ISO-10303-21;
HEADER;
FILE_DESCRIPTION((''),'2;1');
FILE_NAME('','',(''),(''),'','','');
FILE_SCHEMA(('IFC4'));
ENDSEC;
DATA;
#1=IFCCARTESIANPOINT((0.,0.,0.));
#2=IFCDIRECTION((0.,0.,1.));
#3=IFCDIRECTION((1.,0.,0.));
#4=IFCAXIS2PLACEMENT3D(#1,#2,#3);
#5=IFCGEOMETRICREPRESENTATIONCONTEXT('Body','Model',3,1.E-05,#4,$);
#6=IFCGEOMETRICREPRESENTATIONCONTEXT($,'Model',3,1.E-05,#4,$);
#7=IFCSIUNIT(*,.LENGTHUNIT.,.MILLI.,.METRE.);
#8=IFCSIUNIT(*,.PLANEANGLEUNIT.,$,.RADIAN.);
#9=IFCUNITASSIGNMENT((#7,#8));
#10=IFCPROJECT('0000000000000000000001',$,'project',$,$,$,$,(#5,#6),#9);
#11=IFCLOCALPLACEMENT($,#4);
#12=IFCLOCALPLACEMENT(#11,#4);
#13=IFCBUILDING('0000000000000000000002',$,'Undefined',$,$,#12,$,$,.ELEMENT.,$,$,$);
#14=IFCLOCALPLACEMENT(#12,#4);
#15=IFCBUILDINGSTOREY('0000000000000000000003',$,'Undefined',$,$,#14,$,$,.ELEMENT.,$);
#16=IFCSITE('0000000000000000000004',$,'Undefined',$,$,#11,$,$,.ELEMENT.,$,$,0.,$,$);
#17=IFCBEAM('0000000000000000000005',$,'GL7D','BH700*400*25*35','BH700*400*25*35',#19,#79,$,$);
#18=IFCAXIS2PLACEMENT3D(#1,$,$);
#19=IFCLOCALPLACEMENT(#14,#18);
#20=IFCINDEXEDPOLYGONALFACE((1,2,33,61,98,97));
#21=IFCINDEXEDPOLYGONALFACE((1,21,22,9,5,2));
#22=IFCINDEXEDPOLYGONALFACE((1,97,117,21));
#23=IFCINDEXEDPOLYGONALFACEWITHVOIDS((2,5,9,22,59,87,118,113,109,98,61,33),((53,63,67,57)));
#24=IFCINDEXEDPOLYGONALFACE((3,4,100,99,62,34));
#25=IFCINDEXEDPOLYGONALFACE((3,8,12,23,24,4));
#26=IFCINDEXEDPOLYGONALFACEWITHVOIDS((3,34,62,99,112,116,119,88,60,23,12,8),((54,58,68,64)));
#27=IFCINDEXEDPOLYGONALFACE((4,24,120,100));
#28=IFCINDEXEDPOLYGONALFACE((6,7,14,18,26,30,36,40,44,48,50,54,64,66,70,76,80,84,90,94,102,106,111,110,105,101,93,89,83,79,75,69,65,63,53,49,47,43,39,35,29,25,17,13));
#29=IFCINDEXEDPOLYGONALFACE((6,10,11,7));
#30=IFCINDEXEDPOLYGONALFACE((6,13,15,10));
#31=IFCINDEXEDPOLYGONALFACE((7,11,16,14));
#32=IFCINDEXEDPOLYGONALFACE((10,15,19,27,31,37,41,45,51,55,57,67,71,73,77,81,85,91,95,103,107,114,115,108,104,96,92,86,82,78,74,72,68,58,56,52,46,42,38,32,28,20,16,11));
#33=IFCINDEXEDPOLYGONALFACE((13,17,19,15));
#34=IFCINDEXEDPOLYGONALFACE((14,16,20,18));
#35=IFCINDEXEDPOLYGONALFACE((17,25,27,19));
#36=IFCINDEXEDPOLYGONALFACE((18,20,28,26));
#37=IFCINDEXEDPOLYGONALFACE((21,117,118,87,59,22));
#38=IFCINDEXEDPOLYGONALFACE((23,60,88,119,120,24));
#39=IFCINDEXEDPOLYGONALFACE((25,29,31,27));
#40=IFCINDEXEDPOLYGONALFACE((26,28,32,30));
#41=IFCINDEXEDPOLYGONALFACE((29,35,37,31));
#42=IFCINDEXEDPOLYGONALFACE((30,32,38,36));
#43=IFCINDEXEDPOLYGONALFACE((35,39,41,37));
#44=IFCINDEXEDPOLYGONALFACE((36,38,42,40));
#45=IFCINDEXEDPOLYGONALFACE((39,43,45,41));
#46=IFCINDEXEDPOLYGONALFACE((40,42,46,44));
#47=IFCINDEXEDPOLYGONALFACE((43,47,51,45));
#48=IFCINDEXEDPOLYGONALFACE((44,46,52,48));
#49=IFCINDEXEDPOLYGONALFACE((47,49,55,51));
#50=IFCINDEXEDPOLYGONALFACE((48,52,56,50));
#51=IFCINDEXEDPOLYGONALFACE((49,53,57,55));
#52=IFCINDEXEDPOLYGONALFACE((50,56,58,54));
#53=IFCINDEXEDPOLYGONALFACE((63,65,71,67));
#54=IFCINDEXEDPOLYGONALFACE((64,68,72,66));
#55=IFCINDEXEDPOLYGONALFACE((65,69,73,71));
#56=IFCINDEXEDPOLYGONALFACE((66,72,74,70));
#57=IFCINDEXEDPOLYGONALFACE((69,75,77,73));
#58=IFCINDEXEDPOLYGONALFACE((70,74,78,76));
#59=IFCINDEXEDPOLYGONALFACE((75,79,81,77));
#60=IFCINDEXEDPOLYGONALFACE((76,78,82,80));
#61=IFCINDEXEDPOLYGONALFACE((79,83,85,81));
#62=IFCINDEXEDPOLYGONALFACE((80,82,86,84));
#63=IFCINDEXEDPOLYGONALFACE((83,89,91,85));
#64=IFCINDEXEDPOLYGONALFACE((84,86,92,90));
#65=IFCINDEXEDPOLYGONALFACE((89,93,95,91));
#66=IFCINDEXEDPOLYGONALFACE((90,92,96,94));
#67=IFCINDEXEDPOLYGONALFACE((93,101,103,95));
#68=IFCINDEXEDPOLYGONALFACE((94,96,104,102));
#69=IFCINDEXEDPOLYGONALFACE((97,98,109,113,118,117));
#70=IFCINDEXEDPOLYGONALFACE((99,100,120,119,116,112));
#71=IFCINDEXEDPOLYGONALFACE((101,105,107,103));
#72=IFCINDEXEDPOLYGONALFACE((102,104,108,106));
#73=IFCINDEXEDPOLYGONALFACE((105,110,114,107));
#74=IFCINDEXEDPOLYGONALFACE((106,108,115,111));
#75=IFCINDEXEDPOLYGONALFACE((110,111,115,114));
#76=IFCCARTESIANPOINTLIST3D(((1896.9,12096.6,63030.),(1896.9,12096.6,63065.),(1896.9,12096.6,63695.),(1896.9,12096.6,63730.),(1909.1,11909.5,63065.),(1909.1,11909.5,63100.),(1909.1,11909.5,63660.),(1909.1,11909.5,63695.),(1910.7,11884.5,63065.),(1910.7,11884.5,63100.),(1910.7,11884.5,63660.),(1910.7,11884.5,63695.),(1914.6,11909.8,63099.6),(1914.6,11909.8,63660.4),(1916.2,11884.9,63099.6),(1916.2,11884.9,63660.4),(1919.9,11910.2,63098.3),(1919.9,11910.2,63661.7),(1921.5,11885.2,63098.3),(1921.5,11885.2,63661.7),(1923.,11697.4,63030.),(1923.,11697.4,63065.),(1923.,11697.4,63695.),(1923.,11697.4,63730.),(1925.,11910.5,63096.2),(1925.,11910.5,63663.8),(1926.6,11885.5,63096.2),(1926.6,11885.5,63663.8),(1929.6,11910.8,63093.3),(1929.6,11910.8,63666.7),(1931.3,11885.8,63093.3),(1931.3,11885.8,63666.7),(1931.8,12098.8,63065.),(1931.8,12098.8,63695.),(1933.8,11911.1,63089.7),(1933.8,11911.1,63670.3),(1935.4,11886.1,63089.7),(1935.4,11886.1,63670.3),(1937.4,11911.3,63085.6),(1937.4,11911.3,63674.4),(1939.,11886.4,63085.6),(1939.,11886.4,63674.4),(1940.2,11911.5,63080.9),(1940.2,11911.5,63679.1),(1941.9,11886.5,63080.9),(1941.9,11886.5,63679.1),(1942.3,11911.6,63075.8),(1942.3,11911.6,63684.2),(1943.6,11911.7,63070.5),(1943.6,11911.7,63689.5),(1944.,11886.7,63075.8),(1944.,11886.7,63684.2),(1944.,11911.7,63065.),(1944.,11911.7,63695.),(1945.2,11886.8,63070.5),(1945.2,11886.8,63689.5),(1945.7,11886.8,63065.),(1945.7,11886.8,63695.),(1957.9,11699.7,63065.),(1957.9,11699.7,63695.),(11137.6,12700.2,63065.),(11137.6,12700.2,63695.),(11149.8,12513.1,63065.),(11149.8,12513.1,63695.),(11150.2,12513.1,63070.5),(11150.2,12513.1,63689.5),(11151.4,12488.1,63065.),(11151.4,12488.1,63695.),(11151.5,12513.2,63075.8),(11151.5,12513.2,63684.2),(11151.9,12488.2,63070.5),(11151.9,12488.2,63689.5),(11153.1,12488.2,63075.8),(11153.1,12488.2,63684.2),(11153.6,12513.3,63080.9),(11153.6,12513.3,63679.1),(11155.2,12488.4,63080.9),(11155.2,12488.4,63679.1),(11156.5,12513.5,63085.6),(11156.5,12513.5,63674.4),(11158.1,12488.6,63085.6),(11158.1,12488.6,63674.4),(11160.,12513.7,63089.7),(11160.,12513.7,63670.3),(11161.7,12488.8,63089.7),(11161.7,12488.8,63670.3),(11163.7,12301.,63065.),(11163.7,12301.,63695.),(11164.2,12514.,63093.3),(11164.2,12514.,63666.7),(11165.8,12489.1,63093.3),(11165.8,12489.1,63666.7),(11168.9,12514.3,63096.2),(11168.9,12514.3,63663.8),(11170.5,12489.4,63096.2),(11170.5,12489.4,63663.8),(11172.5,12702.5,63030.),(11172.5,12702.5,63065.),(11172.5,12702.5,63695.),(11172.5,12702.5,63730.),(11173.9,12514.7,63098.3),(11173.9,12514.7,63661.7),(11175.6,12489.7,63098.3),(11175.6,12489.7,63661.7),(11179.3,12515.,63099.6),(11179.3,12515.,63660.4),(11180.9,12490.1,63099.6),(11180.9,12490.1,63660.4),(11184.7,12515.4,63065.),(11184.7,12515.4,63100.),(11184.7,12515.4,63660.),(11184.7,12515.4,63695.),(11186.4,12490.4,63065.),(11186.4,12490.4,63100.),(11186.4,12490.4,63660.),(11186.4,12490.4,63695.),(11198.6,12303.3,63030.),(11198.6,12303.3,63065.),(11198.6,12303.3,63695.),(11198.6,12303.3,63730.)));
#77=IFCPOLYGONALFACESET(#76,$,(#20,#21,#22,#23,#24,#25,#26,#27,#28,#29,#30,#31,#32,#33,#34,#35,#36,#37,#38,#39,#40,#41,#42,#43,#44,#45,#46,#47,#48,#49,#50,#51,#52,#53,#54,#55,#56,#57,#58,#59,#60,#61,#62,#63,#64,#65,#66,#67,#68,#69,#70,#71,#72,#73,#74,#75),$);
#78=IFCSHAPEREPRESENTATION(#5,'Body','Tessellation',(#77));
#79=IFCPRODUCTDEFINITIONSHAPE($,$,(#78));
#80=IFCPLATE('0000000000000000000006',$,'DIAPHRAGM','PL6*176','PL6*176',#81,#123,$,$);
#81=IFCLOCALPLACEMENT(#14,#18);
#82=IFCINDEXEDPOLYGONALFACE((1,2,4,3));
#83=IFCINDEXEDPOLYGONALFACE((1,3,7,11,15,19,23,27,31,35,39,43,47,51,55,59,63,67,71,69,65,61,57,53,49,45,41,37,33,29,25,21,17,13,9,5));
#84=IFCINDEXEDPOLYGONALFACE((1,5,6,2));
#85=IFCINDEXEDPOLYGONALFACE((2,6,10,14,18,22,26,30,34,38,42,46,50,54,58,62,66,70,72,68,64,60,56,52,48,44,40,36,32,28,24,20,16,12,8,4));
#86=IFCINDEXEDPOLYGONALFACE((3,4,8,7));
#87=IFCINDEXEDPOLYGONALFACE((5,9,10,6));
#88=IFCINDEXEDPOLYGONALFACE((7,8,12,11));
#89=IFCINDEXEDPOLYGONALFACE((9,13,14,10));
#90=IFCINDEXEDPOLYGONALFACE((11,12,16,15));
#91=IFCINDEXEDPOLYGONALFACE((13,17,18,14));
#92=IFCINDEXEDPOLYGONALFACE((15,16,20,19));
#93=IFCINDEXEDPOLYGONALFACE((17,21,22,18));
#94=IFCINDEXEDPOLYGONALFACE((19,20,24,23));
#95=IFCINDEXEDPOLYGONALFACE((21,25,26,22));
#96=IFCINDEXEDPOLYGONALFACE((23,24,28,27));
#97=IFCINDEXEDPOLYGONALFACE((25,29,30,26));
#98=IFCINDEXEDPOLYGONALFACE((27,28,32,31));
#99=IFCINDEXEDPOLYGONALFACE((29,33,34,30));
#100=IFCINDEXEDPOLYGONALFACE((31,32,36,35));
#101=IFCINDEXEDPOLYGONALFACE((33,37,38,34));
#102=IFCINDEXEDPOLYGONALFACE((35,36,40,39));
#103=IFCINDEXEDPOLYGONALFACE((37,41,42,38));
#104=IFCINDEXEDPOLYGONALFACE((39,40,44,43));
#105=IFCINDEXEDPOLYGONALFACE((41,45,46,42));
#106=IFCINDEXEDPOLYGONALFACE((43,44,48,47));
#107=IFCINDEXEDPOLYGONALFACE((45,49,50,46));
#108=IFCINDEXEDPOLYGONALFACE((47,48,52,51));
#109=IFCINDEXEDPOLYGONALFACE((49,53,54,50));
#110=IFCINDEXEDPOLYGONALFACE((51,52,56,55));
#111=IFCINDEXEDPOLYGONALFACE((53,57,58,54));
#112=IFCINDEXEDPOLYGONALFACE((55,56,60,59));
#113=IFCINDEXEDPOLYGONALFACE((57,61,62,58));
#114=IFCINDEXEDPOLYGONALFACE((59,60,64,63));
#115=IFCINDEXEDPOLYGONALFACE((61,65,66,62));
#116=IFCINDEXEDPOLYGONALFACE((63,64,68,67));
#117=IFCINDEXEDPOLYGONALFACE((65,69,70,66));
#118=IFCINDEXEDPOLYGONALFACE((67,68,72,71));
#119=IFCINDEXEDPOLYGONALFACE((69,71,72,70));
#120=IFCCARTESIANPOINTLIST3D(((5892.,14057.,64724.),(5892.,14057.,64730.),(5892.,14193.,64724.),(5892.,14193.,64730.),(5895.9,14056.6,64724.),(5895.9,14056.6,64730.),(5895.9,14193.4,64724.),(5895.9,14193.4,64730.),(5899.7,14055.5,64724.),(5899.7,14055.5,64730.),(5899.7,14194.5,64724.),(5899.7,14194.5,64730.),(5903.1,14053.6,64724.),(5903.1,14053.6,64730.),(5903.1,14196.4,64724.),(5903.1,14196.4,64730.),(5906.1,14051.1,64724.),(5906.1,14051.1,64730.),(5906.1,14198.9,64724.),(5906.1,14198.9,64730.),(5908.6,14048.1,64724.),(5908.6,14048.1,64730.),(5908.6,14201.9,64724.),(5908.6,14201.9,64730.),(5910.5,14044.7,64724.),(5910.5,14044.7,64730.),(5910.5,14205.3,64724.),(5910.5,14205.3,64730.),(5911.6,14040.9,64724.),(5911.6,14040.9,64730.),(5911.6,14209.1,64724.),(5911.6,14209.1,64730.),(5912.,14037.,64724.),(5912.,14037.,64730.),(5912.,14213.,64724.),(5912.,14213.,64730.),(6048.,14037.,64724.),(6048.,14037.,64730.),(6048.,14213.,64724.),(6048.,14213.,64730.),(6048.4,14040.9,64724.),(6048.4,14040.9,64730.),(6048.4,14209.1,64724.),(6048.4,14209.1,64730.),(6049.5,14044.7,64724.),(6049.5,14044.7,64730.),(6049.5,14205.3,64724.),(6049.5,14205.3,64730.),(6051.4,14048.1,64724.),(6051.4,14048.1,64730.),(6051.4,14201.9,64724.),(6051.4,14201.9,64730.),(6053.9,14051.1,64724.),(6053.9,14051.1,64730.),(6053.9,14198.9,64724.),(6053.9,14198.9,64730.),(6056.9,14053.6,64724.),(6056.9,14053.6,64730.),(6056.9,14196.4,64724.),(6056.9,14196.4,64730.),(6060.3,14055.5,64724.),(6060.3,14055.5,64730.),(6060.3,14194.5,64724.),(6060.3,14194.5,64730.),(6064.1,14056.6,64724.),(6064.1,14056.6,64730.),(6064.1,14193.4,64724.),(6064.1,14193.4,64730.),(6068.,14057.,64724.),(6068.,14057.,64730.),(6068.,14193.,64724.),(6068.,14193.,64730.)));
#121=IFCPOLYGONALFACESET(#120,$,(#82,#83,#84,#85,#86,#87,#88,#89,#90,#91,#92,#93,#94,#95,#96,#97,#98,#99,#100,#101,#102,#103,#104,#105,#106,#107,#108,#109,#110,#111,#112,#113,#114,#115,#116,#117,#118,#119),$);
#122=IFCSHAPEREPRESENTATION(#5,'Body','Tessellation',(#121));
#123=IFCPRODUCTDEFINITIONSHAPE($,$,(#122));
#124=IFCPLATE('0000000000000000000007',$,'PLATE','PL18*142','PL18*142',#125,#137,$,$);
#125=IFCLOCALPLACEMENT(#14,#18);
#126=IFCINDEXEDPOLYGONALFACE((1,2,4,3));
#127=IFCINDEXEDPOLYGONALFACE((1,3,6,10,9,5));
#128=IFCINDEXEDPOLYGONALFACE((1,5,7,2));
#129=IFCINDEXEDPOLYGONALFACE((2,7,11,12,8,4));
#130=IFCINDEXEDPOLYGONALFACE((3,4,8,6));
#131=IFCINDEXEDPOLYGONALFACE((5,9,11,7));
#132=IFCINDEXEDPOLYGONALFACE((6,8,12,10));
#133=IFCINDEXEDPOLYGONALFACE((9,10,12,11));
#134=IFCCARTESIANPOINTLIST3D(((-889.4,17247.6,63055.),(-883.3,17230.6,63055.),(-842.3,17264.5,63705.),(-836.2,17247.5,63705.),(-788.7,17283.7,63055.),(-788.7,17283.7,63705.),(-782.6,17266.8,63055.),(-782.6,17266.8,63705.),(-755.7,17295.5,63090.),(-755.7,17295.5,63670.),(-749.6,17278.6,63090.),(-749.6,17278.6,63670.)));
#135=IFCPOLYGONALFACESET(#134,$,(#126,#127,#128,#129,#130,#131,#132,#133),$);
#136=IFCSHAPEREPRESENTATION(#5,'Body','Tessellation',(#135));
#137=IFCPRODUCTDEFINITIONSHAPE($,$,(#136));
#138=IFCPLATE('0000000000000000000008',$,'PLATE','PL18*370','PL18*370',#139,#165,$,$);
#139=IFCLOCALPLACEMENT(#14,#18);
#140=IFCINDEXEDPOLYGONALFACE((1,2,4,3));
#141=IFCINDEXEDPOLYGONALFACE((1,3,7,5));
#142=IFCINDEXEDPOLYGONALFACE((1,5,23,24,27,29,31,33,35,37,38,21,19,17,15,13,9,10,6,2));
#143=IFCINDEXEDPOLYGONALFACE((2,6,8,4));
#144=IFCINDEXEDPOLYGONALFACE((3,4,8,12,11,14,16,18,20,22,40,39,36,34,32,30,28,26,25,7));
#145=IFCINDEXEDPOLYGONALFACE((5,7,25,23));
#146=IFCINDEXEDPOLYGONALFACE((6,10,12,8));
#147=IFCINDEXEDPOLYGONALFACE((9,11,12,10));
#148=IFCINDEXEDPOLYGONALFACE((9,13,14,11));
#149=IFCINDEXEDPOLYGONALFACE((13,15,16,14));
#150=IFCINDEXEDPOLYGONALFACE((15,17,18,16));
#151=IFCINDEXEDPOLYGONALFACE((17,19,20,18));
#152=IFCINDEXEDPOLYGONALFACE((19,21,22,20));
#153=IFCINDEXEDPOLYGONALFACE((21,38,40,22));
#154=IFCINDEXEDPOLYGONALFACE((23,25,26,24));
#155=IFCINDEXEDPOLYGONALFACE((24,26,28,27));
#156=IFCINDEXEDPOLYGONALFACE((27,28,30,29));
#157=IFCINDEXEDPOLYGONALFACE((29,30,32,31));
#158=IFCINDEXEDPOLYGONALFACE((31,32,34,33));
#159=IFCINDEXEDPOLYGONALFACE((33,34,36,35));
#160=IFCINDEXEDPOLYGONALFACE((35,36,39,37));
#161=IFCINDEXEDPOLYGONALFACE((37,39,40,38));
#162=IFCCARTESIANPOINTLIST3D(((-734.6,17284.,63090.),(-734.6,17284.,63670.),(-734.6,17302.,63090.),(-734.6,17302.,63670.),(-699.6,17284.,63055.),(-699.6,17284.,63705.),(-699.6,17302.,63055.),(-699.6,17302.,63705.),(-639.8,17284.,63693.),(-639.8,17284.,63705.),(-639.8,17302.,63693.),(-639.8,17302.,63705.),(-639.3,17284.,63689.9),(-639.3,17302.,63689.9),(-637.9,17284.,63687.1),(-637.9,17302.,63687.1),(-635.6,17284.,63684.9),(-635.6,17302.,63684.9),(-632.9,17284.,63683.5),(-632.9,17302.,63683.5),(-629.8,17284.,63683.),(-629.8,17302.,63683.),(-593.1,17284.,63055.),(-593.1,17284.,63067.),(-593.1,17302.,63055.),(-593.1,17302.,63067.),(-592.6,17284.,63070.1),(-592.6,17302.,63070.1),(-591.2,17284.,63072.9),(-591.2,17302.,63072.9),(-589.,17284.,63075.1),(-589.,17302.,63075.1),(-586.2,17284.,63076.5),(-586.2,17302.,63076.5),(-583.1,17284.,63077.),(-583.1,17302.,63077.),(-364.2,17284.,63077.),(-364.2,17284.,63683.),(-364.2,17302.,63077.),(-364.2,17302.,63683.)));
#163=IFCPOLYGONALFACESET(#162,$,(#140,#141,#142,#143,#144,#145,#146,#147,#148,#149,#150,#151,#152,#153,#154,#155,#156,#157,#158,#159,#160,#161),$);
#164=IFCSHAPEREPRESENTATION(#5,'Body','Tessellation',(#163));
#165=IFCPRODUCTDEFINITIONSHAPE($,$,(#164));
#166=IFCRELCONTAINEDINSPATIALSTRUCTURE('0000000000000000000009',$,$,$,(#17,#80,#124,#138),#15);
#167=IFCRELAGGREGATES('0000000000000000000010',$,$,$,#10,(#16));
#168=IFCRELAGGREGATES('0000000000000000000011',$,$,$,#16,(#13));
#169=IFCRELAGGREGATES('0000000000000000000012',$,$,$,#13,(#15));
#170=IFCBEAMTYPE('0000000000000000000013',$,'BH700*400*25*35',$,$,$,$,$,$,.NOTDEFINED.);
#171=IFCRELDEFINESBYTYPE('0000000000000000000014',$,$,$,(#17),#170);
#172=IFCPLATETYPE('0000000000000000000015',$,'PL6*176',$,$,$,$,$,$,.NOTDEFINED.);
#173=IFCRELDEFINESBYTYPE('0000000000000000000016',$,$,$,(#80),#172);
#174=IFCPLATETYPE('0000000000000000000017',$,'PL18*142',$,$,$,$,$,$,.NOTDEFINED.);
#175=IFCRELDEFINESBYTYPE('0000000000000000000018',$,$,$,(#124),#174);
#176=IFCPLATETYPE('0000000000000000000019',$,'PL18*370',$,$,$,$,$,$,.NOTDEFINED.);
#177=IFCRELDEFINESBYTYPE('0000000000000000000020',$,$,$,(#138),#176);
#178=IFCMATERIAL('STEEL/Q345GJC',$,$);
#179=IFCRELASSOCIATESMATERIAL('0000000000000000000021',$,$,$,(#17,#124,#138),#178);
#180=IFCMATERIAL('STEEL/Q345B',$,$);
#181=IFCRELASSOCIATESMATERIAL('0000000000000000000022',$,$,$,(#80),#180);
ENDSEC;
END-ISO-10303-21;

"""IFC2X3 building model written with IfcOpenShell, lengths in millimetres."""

from ifc_helpers import new_model, si_unit, frame, origin_with_axes, origin_2d_with_axis, place, context, project, spatial, polyline, i_section, outline, extrude, material, type_object, element, save


model = new_model("IFC2X3")

# Units and contexts
model_context_1 = context("Model", 3, precision=1e-05, world=origin_with_axes(), identifier="Body")
model_context_2 = context("Model", 3, precision=1e-05, world=origin_with_axes())
ifc_project = project(units=[si_unit("LENGTHUNIT", "METRE", prefix="MILLI"), si_unit("PLANEANGLEUNIT", "RADIAN")], contexts=[model_context_1, model_context_2])

# Site, building, storey
site_placement = place(None, origin_with_axes())
site = spatial("IfcSite", under=ifc_project, at=site_placement, Name="Undefined", CompositionType="ELEMENT", RefElevation=0.0)
building_placement = place(site_placement, origin_with_axes())
building = spatial("IfcBuilding", under=site, at=building_placement, Name="Undefined", CompositionType="ELEMENT")
storey_placement = place(building_placement, origin_with_axes())
storey = spatial("IfcBuildingStorey", under=building, at=storey_placement, Name="Undefined", CompositionType="ELEMENT")

# Shared definitions
ifc_material_1 = material(Name="STEEL/Q345B")

# Shared definitions
ifc_material_2 = material(Name="STEEL/Q345GJC")

# Beam, openings
beam_type_1 = type_object("IfcBeamType", Name="BH700*400*25*35", PredefinedType="NOTDEFINED")
beam_1_placement = place(storey_placement, frame((992.3, 11837.0, 63380.0), z_axis=(0.0, 0.0, 1.0), x_axis=(0.997873, 0.065184, 0.0)))
beam_1 = element("IfcBeam", 1, at=beam_1_placement, inside=storey, type_object=beam_type_1, material=ifc_material_2, Name="GL7D", Description="BH700*400*25*35", ObjectType="BH700*400*25*35", context=model_context_1, shape_type="SweptSolid", body=[
    extrude(i_section(OverallWidth=400.0, OverallDepth=700.0, WebThickness=25.0, FlangeThickness=35.0, at=origin_2d_with_axis()), frame((10215.0, 0.0, 0.0), z_axis=(-1.0, 0.0, 0.0), x_axis=(0.0, -1.0, 0.0)), (0.0, 0.0, 1.0), 9295.4),
])
opening_1_placement = place(storey_placement, frame((992.3, 11837.0, 63380.0), z_axis=(0.0, 0.0, 1.0), x_axis=(0.997873, 0.065184, 0.0)))
element("IfcOpeningElement", 2, at=opening_1_placement, cuts=beam_1, ObjectType="Recess", context=model_context_1, shape_type="SweptSolid", body=[
    extrude(outline(polyline([(0.0, 0.0), (37.0, 0.0), (37.0, 35.0), (35.0, 35.0), (29.5, 34.6), (24.2, 33.3), (19.1, 31.2), (14.4, 28.3), (10.3, 24.7), (6.7, 20.6), (3.8, 15.9), (1.7, 10.8), (0.4, 5.5), (0.0, 0.0), (0.0, 0.0)])), frame((10180.0, -200.0, 315.0), z_axis=(0.0, 1.0, 0.0), x_axis=(1.0, 0.0, 0.0)), (0.0, 0.0, 1.0), 400.0),
])
opening_2_placement = place(storey_placement, frame((992.3, 11837.0, 63380.0), z_axis=(0.0, 0.0, 1.0), x_axis=(0.997873, 0.065184, 0.0)))
element("IfcOpeningElement", 3, at=opening_2_placement, cuts=beam_1, ObjectType="Recess", context=model_context_1, shape_type="SweptSolid", body=[
    extrude(outline(polyline([(0.0, 0.0), (37.0, 0.0), (36.6, 5.5), (35.3, 10.8), (33.2, 15.9), (30.3, 20.6), (26.7, 24.7), (22.6, 28.3), (17.9, 31.2), (12.8, 33.3), (7.5, 34.6), (2.0, 35.0), (0.0, 35.0), (0.0, 0.0)])), frame((10217.0, -200.0, -315.0), z_axis=(0.0, 1.0, 0.0), x_axis=(-1.0, 0.0, 0.0)), (0.0, 0.0, 1.0), 400.0),
])
opening_3_placement = place(storey_placement, frame((992.3, 11837.0, 63380.0), z_axis=(0.0, 0.0, 1.0), x_axis=(0.997873, 0.065184, 0.0)))
element("IfcOpeningElement", 4, at=opening_3_placement, cuts=beam_1, ObjectType="Recess", context=model_context_1, shape_type="SweptSolid", body=[
    extrude(outline(polyline([(0.0, 0.0), (37.0, 0.0), (37.0, 35.0), (35.0, 35.0), (29.5, 34.6), (24.2, 33.3), (19.1, 31.2), (14.4, 28.3), (10.3, 24.7), (6.7, 20.6), (3.8, 15.9), (1.7, 10.8), (0.4, 5.5), (0.0, 0.0), (0.0, 0.0)])), frame((954.6, 200.0, 315.0), z_axis=(0.0, -1.0, 0.0), x_axis=(-1.0, 0.0, 0.0)), (0.0, 0.0, 1.0), 400.0),
])
opening_4_placement = place(storey_placement, frame((992.3, 11837.0, 63380.0), z_axis=(0.0, 0.0, 1.0), x_axis=(0.997873, 0.065184, 0.0)))
element("IfcOpeningElement", 5, at=opening_4_placement, cuts=beam_1, ObjectType="Recess", context=model_context_1, shape_type="SweptSolid", body=[
    extrude(outline(polyline([(0.0, 0.0), (37.0, 0.0), (36.6, 5.5), (35.3, 10.8), (33.2, 15.9), (30.3, 20.6), (26.7, 24.7), (22.6, 28.3), (17.9, 31.2), (12.8, 33.3), (7.5, 34.6), (2.0, 35.0), (0.0, 35.0), (0.0, 0.0)])), frame((917.6, 200.0, -315.0), z_axis=(0.0, -1.0, 0.0), x_axis=(1.0, 0.0, 0.0)), (0.0, 0.0, 1.0), 400.0),
])

# Plates
plate_type_1 = type_object("IfcPlateType", Name="PL6*176", PredefinedType="NOTDEFINED")
plate_1_placement = place(storey_placement, frame((6068.0, 14037.0, 64727.0), z_axis=(0.0, 0.0, -1.0), x_axis=(-1.0, 0.0, 0.0)))
element("IfcPlate", 6, at=plate_1_placement, inside=storey, type_object=plate_type_1, material=ifc_material_1, Name="DIAPHRAGM", Description="PL6*176", ObjectType="PL6*176", context=model_context_1, shape_type="SweptSolid", body=[
    extrude(outline(polyline([(0.0, 20.0), (3.9, 19.6), (7.7, 18.5), (11.1, 16.6), (14.1, 14.1), (16.6, 11.1), (18.5, 7.7), (19.6, 3.9), (20.0, 0.0), (156.0, 0.0), (156.4, 3.9), (157.5, 7.7), (159.4, 11.1), (161.9, 14.1), (164.9, 16.6), (168.3, 18.5), (172.1, 19.6), (176.0, 20.0), (176.0, 156.0), (172.1, 156.4), (168.3, 157.5), (164.9, 159.4), (161.9, 161.9), (159.4, 164.9), (157.5, 168.3), (156.4, 172.1), (156.0, 176.0), (20.0, 176.0), (19.6, 172.1), (18.5, 168.3), (16.6, 164.9), (14.1, 161.9), (11.1, 159.4), (7.7, 157.5), (3.9, 156.4), (0.0, 156.0), (0.0, 20.0)])), frame((0.0, 0.0, -3.0), z_axis=(0.0, 0.0, 1.0), x_axis=(1.0, 0.0, 0.0)), (0.0, 0.0, 1.0), 6.0),
])
plate_type_2 = type_object("IfcPlateType", Name="PL18*142", PredefinedType="NOTDEFINED")
plate_2_placement = place(storey_placement, frame((-752.7, 17287.1, 63705.0), z_axis=(0.337816, -0.941212, 0.0), x_axis=(-0.941212, -0.337816, 0.0)))
element("IfcPlate", 7, at=plate_2_placement, inside=storey, type_object=plate_type_2, material=ifc_material_2, Name="PLATE", Description="PL18*142", ObjectType="PL18*142", context=model_context_1, shape_type="SweptSolid", body=[
    extrude(outline(polyline([(0.0, 35.0), (35.0, 0.0), (92.0, 0.0), (142.0, 650.0), (35.0, 650.0), (0.0, 615.0), (0.0, 35.0)])), frame((0.0, 0.0, -9.0), z_axis=(0.0, 0.0, 1.0), x_axis=(1.0, 0.0, 0.0)), (0.0, 0.0, 1.0), 18.0),
])
plate_type_3 = type_object("IfcPlateType", Name="PL18*370", PredefinedType="NOTDEFINED")
plate_3_placement = place(storey_placement, frame((-639.8, 17293.0, 63705.0), z_axis=(0.0, -1.0, 0.0), x_axis=(-1.0, 0.0, 0.0)))
element("IfcPlate", 8, at=plate_3_placement, inside=storey, type_object=plate_type_3, material=ifc_material_2, Name="PLATE", Description="PL18*370", ObjectType="PL18*370", context=model_context_1, shape_type="SweptSolid", body=[
    extrude(outline(polyline([(0.0, 0.0), (59.8, 0.0), (94.8, 35.0), (94.8, 615.0), (59.8, 650.0), (-46.7, 650.0), (-46.7, 638.0), (-47.2, 634.9), (-48.6, 632.1), (-50.8, 629.9), (-53.6, 628.5), (-56.7, 628.0), (-275.6, 628.0), (-275.6, 22.0), (-10.0, 22.0), (-6.9, 21.5), (-4.1, 20.1), (-1.9, 17.9), (-0.5, 15.1), (0.0, 12.0), (0.0, 0.0)])), frame((0.0, 0.0, -9.0), z_axis=(0.0, 0.0, 1.0), x_axis=(1.0, 0.0, 0.0)), (0.0, 0.0, 1.0), 18.0),
])

save(model, "model.ifc")
